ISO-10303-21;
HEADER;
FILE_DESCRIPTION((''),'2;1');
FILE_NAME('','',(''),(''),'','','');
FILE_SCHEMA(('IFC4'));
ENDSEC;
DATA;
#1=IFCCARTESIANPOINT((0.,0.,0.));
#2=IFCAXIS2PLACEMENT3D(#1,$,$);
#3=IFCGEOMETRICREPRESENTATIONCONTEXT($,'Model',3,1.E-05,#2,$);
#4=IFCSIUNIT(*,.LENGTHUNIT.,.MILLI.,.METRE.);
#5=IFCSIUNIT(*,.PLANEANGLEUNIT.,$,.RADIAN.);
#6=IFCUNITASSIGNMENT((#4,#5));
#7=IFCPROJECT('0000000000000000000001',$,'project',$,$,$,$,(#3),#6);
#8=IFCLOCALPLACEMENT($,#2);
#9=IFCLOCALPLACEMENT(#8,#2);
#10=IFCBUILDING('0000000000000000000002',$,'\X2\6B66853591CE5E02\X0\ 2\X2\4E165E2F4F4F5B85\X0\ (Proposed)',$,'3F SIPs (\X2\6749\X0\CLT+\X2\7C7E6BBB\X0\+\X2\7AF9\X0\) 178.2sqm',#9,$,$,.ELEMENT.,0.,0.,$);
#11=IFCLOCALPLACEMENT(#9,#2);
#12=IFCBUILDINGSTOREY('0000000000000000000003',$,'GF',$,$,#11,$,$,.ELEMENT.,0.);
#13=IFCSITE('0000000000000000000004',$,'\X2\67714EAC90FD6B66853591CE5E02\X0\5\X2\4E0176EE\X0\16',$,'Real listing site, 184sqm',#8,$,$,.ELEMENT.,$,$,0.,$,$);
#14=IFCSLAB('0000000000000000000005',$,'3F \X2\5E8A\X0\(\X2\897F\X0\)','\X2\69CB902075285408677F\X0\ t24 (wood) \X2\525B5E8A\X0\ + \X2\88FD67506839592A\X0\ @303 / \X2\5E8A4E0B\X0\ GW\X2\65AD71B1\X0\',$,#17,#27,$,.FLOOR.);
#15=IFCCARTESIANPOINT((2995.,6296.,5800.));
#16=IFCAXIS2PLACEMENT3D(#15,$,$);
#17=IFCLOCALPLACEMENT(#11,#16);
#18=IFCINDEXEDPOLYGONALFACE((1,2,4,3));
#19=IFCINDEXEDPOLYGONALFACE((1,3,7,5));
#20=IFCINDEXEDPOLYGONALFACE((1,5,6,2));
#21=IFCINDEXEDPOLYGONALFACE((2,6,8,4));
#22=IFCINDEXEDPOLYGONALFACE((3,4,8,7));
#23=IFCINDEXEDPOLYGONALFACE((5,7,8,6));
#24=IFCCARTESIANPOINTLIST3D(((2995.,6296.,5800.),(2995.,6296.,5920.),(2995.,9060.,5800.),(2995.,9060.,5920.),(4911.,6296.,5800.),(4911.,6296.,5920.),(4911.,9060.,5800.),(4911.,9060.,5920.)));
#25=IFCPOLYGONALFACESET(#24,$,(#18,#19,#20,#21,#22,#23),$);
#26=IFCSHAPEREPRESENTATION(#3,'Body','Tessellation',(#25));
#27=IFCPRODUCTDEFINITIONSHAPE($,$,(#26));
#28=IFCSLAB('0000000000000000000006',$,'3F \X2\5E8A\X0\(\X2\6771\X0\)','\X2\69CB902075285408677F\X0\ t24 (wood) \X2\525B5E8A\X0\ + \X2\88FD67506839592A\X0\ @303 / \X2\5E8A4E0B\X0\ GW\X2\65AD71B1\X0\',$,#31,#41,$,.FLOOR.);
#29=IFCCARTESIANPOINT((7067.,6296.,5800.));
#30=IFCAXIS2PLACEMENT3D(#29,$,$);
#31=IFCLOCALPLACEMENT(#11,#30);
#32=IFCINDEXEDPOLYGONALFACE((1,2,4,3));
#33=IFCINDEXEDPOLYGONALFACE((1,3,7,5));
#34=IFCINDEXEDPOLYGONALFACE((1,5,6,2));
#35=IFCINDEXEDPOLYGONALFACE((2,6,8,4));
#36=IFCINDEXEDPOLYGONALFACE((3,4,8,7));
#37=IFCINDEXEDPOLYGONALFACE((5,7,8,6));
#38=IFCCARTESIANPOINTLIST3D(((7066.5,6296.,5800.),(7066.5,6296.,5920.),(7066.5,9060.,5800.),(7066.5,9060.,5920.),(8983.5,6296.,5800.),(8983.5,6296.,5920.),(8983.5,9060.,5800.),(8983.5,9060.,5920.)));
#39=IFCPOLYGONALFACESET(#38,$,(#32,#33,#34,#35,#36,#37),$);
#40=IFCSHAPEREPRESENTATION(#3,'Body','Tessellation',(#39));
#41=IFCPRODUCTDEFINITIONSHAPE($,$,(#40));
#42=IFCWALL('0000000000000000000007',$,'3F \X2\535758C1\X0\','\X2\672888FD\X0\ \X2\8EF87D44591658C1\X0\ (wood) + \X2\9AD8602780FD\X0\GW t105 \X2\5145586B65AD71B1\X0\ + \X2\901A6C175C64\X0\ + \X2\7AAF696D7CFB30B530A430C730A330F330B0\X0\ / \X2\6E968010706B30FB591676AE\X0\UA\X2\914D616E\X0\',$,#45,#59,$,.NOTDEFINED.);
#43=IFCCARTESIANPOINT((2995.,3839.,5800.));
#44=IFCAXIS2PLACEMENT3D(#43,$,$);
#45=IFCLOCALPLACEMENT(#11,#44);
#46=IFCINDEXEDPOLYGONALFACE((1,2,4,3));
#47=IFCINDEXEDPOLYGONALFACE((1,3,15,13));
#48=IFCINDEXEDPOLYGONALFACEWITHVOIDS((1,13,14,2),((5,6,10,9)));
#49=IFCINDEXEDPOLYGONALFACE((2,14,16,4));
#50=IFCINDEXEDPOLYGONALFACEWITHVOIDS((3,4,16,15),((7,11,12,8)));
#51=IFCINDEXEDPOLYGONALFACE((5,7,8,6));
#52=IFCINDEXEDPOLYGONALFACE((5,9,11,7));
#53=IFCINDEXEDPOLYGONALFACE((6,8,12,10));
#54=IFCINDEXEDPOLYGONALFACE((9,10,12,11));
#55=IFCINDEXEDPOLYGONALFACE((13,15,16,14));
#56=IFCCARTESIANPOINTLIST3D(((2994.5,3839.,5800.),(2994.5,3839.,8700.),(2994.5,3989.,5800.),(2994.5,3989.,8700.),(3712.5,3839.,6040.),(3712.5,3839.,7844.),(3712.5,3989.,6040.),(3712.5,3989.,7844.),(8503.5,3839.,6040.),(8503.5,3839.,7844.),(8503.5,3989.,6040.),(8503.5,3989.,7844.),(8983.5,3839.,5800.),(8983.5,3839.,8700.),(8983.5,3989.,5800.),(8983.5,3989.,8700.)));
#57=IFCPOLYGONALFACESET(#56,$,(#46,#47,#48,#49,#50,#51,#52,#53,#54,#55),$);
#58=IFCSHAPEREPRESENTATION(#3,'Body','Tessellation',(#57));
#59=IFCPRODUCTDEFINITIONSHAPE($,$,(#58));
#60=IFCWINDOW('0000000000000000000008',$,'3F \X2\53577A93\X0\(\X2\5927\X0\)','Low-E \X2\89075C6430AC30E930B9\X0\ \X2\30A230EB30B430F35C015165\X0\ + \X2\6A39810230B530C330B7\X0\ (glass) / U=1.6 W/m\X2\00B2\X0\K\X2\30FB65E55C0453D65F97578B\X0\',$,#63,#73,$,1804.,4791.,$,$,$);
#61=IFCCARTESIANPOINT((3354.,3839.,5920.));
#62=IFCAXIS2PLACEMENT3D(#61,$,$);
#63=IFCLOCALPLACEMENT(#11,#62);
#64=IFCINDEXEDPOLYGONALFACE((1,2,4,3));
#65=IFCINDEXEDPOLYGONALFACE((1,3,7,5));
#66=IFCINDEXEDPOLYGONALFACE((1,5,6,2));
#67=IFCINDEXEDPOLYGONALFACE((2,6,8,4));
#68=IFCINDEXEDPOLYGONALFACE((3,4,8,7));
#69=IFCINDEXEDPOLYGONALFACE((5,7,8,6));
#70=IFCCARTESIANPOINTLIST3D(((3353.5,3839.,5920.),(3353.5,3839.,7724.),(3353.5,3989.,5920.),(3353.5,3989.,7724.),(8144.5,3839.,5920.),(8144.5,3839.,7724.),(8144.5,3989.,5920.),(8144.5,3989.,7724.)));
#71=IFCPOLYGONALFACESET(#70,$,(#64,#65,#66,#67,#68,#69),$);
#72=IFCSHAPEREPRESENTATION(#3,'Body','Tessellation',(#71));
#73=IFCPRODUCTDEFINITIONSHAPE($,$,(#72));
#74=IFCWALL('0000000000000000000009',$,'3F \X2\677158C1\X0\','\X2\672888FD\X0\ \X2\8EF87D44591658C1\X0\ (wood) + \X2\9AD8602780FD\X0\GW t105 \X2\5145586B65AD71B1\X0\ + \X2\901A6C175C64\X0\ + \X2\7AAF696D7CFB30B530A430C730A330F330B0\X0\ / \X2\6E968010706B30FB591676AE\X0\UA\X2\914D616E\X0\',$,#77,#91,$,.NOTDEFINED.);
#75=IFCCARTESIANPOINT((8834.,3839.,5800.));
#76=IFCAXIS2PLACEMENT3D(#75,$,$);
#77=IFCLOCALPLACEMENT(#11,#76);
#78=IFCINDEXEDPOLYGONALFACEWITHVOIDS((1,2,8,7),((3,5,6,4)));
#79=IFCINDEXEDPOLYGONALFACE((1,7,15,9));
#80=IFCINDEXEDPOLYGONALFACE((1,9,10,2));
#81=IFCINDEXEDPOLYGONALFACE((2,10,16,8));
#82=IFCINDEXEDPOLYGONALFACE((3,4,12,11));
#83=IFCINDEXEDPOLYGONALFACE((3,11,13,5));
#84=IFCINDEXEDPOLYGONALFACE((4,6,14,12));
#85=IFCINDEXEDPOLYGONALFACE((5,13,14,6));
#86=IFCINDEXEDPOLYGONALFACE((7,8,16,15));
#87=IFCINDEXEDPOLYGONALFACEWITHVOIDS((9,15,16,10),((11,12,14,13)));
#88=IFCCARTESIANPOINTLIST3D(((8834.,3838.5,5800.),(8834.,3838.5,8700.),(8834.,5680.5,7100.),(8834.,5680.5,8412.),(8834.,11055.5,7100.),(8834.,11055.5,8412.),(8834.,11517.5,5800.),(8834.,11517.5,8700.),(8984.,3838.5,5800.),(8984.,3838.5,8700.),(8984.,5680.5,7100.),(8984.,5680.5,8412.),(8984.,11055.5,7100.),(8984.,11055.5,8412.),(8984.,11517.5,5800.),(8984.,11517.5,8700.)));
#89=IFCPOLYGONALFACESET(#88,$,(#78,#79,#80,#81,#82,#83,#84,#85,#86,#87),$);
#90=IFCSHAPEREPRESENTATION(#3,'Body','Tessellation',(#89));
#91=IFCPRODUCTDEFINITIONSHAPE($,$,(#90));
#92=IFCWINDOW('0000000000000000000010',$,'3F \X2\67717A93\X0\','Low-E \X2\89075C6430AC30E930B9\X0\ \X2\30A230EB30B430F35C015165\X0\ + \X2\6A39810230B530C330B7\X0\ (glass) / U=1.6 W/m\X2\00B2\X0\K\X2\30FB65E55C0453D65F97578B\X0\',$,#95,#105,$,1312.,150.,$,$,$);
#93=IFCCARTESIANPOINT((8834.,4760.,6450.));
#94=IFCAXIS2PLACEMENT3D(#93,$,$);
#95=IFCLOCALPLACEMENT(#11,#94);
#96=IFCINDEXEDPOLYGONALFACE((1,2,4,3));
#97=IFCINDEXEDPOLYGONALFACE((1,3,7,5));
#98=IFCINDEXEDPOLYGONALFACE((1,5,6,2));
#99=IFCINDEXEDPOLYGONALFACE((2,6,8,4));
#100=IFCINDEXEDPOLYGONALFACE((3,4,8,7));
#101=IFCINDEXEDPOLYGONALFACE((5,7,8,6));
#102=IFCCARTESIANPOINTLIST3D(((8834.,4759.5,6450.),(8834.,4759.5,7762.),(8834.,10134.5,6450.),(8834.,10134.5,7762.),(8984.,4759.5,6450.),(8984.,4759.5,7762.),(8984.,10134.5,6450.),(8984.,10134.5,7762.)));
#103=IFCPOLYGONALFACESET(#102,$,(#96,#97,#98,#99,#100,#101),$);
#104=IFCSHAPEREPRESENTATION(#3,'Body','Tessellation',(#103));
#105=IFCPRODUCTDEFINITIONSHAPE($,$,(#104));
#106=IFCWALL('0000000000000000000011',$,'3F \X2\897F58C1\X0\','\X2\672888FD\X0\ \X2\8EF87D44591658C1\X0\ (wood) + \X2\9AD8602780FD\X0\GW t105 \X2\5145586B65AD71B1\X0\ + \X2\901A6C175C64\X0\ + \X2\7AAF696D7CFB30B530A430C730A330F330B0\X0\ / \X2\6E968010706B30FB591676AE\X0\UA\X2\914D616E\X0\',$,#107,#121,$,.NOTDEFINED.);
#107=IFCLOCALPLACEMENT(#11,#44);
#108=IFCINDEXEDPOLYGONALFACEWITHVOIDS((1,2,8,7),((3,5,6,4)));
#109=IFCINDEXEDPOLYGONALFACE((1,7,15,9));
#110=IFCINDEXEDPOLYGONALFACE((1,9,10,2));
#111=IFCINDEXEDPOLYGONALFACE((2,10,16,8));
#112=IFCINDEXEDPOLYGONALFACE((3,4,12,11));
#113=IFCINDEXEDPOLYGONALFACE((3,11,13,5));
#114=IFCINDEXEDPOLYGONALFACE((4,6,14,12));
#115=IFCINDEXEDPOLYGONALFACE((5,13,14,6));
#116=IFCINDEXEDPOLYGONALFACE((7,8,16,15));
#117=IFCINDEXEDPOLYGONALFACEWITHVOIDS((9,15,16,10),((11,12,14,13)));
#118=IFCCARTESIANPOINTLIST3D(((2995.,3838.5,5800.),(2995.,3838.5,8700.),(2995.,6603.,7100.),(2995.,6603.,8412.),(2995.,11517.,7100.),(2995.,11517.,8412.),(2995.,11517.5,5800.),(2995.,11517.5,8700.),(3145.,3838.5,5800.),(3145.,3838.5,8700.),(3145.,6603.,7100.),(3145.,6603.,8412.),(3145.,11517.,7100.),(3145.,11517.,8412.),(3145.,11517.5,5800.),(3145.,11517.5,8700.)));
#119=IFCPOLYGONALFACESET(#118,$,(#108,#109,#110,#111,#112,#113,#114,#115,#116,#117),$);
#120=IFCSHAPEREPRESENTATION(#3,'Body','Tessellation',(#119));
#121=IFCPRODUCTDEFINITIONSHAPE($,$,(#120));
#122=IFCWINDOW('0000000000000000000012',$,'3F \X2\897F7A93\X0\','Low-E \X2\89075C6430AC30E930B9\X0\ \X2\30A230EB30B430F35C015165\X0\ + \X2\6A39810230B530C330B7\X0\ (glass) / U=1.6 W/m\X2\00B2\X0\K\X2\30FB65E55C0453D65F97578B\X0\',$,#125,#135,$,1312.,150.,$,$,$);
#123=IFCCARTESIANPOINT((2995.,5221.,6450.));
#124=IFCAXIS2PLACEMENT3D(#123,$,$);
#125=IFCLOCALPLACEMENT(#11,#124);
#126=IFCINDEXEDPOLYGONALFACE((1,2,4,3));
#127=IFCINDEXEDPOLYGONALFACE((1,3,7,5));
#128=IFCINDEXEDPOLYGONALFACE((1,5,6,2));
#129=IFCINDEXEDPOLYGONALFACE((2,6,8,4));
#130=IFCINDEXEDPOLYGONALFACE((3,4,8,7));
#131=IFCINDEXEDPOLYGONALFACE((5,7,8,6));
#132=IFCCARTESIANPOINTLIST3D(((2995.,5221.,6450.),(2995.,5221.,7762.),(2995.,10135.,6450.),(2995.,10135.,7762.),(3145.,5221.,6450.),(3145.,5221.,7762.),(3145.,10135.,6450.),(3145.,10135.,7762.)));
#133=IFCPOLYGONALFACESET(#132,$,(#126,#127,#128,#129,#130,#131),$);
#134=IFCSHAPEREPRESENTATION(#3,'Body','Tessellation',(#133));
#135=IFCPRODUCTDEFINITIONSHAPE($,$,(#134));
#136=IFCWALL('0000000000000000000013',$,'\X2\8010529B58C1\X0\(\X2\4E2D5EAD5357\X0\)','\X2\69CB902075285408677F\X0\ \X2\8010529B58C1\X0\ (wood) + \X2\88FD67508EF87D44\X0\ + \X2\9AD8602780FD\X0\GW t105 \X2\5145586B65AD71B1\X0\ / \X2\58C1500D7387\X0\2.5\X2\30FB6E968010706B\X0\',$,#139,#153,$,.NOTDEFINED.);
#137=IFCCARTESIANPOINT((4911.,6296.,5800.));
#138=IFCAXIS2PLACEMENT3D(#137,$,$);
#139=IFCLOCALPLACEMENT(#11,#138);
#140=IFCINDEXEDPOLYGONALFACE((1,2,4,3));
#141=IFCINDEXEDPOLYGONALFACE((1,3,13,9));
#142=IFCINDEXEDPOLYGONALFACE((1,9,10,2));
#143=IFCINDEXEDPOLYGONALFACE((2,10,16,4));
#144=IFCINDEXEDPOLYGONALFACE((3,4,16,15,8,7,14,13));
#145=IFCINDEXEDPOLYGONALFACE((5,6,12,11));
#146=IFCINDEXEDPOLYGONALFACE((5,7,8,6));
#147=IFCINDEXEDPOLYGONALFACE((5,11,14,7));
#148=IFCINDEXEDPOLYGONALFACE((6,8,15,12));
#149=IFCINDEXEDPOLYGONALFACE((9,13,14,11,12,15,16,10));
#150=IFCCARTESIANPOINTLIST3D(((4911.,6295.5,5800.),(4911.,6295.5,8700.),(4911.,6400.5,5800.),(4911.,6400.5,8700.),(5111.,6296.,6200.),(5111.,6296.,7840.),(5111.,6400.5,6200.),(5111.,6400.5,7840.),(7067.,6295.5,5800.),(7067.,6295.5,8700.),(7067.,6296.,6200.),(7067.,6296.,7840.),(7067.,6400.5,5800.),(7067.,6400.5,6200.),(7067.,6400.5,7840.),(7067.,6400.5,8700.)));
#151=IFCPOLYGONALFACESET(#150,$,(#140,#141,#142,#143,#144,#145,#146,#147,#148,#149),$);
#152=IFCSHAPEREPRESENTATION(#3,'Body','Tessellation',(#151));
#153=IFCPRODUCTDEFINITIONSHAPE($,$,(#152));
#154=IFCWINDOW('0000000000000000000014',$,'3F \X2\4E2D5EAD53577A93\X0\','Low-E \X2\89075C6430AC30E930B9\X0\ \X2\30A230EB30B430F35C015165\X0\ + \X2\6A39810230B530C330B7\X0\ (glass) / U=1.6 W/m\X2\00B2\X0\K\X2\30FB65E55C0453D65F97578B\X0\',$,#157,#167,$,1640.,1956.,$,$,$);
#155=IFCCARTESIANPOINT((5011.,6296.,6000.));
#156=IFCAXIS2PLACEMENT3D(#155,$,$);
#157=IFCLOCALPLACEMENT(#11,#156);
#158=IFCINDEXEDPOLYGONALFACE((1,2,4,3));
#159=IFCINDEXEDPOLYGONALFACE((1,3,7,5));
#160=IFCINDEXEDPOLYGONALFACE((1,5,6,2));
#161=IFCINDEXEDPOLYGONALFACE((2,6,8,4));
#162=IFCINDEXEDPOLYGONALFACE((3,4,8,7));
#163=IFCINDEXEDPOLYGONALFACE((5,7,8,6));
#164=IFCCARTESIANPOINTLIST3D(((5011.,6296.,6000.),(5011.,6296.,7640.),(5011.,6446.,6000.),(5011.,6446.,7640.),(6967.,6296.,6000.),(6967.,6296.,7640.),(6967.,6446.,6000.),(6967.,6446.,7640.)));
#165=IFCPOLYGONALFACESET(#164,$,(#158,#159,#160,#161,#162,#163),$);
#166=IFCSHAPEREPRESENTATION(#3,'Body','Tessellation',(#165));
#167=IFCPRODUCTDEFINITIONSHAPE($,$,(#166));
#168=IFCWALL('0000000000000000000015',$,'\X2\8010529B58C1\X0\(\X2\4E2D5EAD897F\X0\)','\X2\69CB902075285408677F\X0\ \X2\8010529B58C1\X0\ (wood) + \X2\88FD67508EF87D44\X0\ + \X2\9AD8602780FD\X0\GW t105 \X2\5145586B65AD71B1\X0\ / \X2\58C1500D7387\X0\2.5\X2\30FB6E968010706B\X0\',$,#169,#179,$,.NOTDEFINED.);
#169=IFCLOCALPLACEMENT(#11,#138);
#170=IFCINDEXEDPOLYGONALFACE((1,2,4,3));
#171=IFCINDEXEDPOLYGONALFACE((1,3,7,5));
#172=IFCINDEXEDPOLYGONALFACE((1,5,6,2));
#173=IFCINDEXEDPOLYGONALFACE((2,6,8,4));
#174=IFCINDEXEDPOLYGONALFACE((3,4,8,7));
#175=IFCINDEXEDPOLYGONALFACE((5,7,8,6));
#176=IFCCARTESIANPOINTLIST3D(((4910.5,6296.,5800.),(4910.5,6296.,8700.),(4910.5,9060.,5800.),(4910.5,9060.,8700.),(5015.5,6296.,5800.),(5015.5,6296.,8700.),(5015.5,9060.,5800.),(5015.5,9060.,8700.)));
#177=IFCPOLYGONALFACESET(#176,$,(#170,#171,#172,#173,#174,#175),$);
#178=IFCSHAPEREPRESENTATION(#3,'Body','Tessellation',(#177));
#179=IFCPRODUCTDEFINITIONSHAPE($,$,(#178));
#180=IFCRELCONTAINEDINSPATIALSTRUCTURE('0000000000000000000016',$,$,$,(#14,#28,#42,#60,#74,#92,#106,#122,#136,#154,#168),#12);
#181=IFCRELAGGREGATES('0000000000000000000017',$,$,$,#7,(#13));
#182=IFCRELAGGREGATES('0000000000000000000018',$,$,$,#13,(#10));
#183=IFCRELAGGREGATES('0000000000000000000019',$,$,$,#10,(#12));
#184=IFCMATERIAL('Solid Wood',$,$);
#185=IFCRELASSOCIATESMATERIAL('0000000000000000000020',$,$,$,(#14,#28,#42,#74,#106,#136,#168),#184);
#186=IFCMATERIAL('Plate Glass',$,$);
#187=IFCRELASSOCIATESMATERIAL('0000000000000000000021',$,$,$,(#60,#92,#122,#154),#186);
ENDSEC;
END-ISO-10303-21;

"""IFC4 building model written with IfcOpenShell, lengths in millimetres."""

from ifc_helpers import new_model, si_unit, frame, frame_2d, origin, place, context, project, spatial, rectangle, extrude, material, element, fill, save


model = new_model("IFC4")

# Units and contexts
model_context = context("Model", 3, precision=1e-05, world=origin())
ifc_project = project(units=[si_unit("LENGTHUNIT", "METRE", prefix="MILLI"), si_unit("PLANEANGLEUNIT", "RADIAN")], contexts=[model_context])

# Site, building, storey
site_placement = place(None, origin())
site = spatial("IfcSite", under=ifc_project, at=site_placement, Name="東京都武蔵野市5丁目16", ObjectType="Real listing site, 184sqm", CompositionType="ELEMENT", RefElevation=0.0)
building_placement = place(site_placement, origin())
building = spatial("IfcBuilding", under=site, at=building_placement, Name="武蔵野市 2世帯住宅 (Proposed)", ObjectType="3F SIPs (杉CLT+籾殻+竹) 178.2sqm", CompositionType="ELEMENT", ElevationOfRefHeight=0.0, ElevationOfTerrain=0.0)
storey_placement = place(building_placement, origin())
storey = spatial("IfcBuildingStorey", under=building, at=storey_placement, Name="GF", CompositionType="ELEMENT", Elevation=0.0)

# Slabs
ifc_material_1 = material(Name="Solid Wood")
slab_1_placement = place(storey_placement, frame((2995.0, 6296.0, 5800.0)))
element("IfcSlab", 1, at=slab_1_placement, inside=storey, material=ifc_material_1, Name="3F 床(西)", Description="構造用合板 t24 (wood) 剛床 + 製材根太 @303 / 床下 GW断熱", PredefinedType="FLOOR", context=model_context, shape_type="SweptSolid", body=[
    extrude(rectangle(XDim=1916.0, YDim=2764.0, at=frame_2d((958.0, 1382.0))), frame((2995.0, 6296.0, 5800.0)), (0.0, 0.0, 1.0), 120.0),
])
slab_2_placement = place(storey_placement, frame((7067.0, 6296.0, 5800.0)))
element("IfcSlab", 2, at=slab_2_placement, inside=storey, material=ifc_material_1, Name="3F 床(東)", Description="構造用合板 t24 (wood) 剛床 + 製材根太 @303 / 床下 GW断熱", PredefinedType="FLOOR", context=model_context, shape_type="SweptSolid", body=[
    extrude(rectangle(XDim=1917.0, YDim=2764.0, at=frame_2d((958.0, 1382.0))), frame((7067.0, 6296.0, 5800.0)), (0.0, 0.0, 1.0), 120.0),
])

# Walls, openings, windows
wall_1_placement = place(storey_placement, frame((2995.0, 3839.0, 5800.0)))
wall_1 = element("IfcWall", 3, at=wall_1_placement, inside=storey, material=ifc_material_1, Name="3F 南壁", Description="木製 軸組外壁 (wood) + 高性能GW t105 充填断熱 + 通気層 + 窯業系サイディング / 準耐火・外皮UA配慮", PredefinedType="NOTDEFINED", context=model_context, shape_type="SweptSolid", body=[
    extrude(rectangle(XDim=5989.0, YDim=150.0, at=frame_2d((2994.0, 75.0))), frame((2995.0, 3839.0, 5800.0)), (0.0, 0.0, 1.0), 2900.0),
])
opening_1_placement = place(storey_placement, frame((3354.0, 3839.0, 5920.0)))
opening_1 = element("IfcOpeningElement", 4, at=opening_1_placement, cuts=wall_1, PredefinedType="NOTDEFINED", context=model_context, shape_type="SweptSolid", body=[
    extrude(rectangle(XDim=4791.0, YDim=150.0, at=frame_2d((2395.0, 75.0))), frame((3354.0, 3839.0, 5920.0)), (0.0, 0.0, 1.0), 1804.0),
])
ifc_material_2 = material(Name="Plate Glass")
window_1_placement = place(storey_placement, frame((3354.0, 3839.0, 5920.0)))
window_1 = element("IfcWindow", 5, at=window_1_placement, inside=storey, material=ifc_material_2, Name="3F 南窓(大)", Description="Low-E 複層ガラス アルゴン封入 + 樹脂サッシ (glass) / U=1.6 W/m²K・日射取得型", OverallHeight=1804.0, OverallWidth=4791.0, context=model_context, shape_type="SweptSolid", body=[
    extrude(rectangle(XDim=4791.0, YDim=150.0, at=frame_2d((2395.0, 75.0))), frame((3354.0, 3839.0, 5920.0)), (0.0, 0.0, 1.0), 1804.0),
])
fill(opening_1, window_1)
wall_2_placement = place(storey_placement, frame((8834.0, 3839.0, 5800.0)))
wall_2 = element("IfcWall", 6, at=wall_2_placement, inside=storey, material=ifc_material_1, Name="3F 東壁", Description="木製 軸組外壁 (wood) + 高性能GW t105 充填断熱 + 通気層 + 窯業系サイディング / 準耐火・外皮UA配慮", PredefinedType="NOTDEFINED", context=model_context, shape_type="SweptSolid", body=[
    extrude(rectangle(XDim=150.0, YDim=7679.0, at=frame_2d((75.0, 3839.0))), frame((8834.0, 3839.0, 5800.0)), (0.0, 0.0, 1.0), 2900.0),
])
opening_2_placement = place(storey_placement, frame((8834.0, 4760.0, 6450.0)))
opening_2 = element("IfcOpeningElement", 7, at=opening_2_placement, cuts=wall_2, PredefinedType="NOTDEFINED", context=model_context, shape_type="SweptSolid", body=[
    extrude(rectangle(XDim=150.0, YDim=5375.0, at=frame_2d((75.0, 2687.0))), frame((8834.0, 4760.0, 6450.0)), (0.0, 0.0, 1.0), 1312.0),
])
window_2_placement = place(storey_placement, frame((8834.0, 4760.0, 6450.0)))
window_2 = element("IfcWindow", 8, at=window_2_placement, inside=storey, material=ifc_material_2, Name="3F 東窓", Description="Low-E 複層ガラス アルゴン封入 + 樹脂サッシ (glass) / U=1.6 W/m²K・日射取得型", OverallHeight=1312.0, OverallWidth=150.0, context=model_context, shape_type="SweptSolid", body=[
    extrude(rectangle(XDim=150.0, YDim=5375.0, at=frame_2d((75.0, 2687.0))), frame((8834.0, 4760.0, 6450.0)), (0.0, 0.0, 1.0), 1312.0),
])
fill(opening_2, window_2)
wall_3_placement = place(storey_placement, frame((2995.0, 3839.0, 5800.0)))
wall_3 = element("IfcWall", 9, at=wall_3_placement, inside=storey, material=ifc_material_1, Name="3F 西壁", Description="木製 軸組外壁 (wood) + 高性能GW t105 充填断熱 + 通気層 + 窯業系サイディング / 準耐火・外皮UA配慮", PredefinedType="NOTDEFINED", context=model_context, shape_type="SweptSolid", body=[
    extrude(rectangle(XDim=150.0, YDim=7679.0, at=frame_2d((75.0, 3839.0))), frame((2995.0, 3839.0, 5800.0)), (0.0, 0.0, 1.0), 2900.0),
])
opening_3_placement = place(storey_placement, frame((2995.0, 5221.0, 6450.0)))
opening_3 = element("IfcOpeningElement", 10, at=opening_3_placement, cuts=wall_3, PredefinedType="NOTDEFINED", context=model_context, shape_type="SweptSolid", body=[
    extrude(rectangle(XDim=150.0, YDim=4914.0, at=frame_2d((75.0, 2457.0))), frame((2995.0, 5221.0, 6450.0)), (0.0, 0.0, 1.0), 1312.0),
])
window_3_placement = place(storey_placement, frame((2995.0, 5221.0, 6450.0)))
window_3 = element("IfcWindow", 11, at=window_3_placement, inside=storey, material=ifc_material_2, Name="3F 西窓", Description="Low-E 複層ガラス アルゴン封入 + 樹脂サッシ (glass) / U=1.6 W/m²K・日射取得型", OverallHeight=1312.0, OverallWidth=150.0, context=model_context, shape_type="SweptSolid", body=[
    extrude(rectangle(XDim=150.0, YDim=4914.0, at=frame_2d((75.0, 2457.0))), frame((2995.0, 5221.0, 6450.0)), (0.0, 0.0, 1.0), 1312.0),
])
fill(opening_3, window_3)
wall_4_placement = place(storey_placement, frame((4911.0, 6296.0, 5800.0)))
wall_4 = element("IfcWall", 12, at=wall_4_placement, inside=storey, material=ifc_material_1, Name="耐力壁(中庭南)", Description="構造用合板 耐力壁 (wood) + 製材軸組 + 高性能GW t105 充填断熱 / 壁倍率2.5・準耐火", PredefinedType="NOTDEFINED", context=model_context, shape_type="SweptSolid", body=[
    extrude(rectangle(XDim=2156.0, YDim=105.0, at=frame_2d((1078.0, 52.0))), frame((4911.0, 6296.0, 5800.0)), (0.0, 0.0, 1.0), 2900.0),
])
opening_4_placement = place(storey_placement, frame((5011.0, 6296.0, 6000.0)))
opening_4 = element("IfcOpeningElement", 13, at=opening_4_placement, cuts=wall_4, PredefinedType="NOTDEFINED", context=model_context, shape_type="SweptSolid", body=[
    extrude(rectangle(XDim=1956.0, YDim=150.0, at=frame_2d((978.0, 75.0))), frame((5011.0, 6296.0, 6000.0)), (0.0, 0.0, 1.0), 1640.0),
])
window_4_placement = place(storey_placement, frame((5011.0, 6296.0, 6000.0)))
window_4 = element("IfcWindow", 14, at=window_4_placement, inside=storey, material=ifc_material_2, Name="3F 中庭南窓", Description="Low-E 複層ガラス アルゴン封入 + 樹脂サッシ (glass) / U=1.6 W/m²K・日射取得型", OverallHeight=1640.0, OverallWidth=1956.0, context=model_context, shape_type="SweptSolid", body=[
    extrude(rectangle(XDim=1956.0, YDim=150.0, at=frame_2d((978.0, 75.0))), frame((5011.0, 6296.0, 6000.0)), (0.0, 0.0, 1.0), 1640.0),
])
fill(opening_4, window_4)

# Wall
wall_5_placement = place(storey_placement, frame((4911.0, 6296.0, 5800.0)))
element("IfcWall", 15, at=wall_5_placement, inside=storey, material=ifc_material_1, Name="耐力壁(中庭西)", Description="構造用合板 耐力壁 (wood) + 製材軸組 + 高性能GW t105 充填断熱 / 壁倍率2.5・準耐火", PredefinedType="NOTDEFINED", context=model_context, shape_type="SweptSolid", body=[
    extrude(rectangle(XDim=105.0, YDim=2764.0, at=frame_2d((52.0, 1382.0))), frame((4911.0, 6296.0, 5800.0)), (0.0, 0.0, 1.0), 2900.0),
])

save(model, "model.ifc")
